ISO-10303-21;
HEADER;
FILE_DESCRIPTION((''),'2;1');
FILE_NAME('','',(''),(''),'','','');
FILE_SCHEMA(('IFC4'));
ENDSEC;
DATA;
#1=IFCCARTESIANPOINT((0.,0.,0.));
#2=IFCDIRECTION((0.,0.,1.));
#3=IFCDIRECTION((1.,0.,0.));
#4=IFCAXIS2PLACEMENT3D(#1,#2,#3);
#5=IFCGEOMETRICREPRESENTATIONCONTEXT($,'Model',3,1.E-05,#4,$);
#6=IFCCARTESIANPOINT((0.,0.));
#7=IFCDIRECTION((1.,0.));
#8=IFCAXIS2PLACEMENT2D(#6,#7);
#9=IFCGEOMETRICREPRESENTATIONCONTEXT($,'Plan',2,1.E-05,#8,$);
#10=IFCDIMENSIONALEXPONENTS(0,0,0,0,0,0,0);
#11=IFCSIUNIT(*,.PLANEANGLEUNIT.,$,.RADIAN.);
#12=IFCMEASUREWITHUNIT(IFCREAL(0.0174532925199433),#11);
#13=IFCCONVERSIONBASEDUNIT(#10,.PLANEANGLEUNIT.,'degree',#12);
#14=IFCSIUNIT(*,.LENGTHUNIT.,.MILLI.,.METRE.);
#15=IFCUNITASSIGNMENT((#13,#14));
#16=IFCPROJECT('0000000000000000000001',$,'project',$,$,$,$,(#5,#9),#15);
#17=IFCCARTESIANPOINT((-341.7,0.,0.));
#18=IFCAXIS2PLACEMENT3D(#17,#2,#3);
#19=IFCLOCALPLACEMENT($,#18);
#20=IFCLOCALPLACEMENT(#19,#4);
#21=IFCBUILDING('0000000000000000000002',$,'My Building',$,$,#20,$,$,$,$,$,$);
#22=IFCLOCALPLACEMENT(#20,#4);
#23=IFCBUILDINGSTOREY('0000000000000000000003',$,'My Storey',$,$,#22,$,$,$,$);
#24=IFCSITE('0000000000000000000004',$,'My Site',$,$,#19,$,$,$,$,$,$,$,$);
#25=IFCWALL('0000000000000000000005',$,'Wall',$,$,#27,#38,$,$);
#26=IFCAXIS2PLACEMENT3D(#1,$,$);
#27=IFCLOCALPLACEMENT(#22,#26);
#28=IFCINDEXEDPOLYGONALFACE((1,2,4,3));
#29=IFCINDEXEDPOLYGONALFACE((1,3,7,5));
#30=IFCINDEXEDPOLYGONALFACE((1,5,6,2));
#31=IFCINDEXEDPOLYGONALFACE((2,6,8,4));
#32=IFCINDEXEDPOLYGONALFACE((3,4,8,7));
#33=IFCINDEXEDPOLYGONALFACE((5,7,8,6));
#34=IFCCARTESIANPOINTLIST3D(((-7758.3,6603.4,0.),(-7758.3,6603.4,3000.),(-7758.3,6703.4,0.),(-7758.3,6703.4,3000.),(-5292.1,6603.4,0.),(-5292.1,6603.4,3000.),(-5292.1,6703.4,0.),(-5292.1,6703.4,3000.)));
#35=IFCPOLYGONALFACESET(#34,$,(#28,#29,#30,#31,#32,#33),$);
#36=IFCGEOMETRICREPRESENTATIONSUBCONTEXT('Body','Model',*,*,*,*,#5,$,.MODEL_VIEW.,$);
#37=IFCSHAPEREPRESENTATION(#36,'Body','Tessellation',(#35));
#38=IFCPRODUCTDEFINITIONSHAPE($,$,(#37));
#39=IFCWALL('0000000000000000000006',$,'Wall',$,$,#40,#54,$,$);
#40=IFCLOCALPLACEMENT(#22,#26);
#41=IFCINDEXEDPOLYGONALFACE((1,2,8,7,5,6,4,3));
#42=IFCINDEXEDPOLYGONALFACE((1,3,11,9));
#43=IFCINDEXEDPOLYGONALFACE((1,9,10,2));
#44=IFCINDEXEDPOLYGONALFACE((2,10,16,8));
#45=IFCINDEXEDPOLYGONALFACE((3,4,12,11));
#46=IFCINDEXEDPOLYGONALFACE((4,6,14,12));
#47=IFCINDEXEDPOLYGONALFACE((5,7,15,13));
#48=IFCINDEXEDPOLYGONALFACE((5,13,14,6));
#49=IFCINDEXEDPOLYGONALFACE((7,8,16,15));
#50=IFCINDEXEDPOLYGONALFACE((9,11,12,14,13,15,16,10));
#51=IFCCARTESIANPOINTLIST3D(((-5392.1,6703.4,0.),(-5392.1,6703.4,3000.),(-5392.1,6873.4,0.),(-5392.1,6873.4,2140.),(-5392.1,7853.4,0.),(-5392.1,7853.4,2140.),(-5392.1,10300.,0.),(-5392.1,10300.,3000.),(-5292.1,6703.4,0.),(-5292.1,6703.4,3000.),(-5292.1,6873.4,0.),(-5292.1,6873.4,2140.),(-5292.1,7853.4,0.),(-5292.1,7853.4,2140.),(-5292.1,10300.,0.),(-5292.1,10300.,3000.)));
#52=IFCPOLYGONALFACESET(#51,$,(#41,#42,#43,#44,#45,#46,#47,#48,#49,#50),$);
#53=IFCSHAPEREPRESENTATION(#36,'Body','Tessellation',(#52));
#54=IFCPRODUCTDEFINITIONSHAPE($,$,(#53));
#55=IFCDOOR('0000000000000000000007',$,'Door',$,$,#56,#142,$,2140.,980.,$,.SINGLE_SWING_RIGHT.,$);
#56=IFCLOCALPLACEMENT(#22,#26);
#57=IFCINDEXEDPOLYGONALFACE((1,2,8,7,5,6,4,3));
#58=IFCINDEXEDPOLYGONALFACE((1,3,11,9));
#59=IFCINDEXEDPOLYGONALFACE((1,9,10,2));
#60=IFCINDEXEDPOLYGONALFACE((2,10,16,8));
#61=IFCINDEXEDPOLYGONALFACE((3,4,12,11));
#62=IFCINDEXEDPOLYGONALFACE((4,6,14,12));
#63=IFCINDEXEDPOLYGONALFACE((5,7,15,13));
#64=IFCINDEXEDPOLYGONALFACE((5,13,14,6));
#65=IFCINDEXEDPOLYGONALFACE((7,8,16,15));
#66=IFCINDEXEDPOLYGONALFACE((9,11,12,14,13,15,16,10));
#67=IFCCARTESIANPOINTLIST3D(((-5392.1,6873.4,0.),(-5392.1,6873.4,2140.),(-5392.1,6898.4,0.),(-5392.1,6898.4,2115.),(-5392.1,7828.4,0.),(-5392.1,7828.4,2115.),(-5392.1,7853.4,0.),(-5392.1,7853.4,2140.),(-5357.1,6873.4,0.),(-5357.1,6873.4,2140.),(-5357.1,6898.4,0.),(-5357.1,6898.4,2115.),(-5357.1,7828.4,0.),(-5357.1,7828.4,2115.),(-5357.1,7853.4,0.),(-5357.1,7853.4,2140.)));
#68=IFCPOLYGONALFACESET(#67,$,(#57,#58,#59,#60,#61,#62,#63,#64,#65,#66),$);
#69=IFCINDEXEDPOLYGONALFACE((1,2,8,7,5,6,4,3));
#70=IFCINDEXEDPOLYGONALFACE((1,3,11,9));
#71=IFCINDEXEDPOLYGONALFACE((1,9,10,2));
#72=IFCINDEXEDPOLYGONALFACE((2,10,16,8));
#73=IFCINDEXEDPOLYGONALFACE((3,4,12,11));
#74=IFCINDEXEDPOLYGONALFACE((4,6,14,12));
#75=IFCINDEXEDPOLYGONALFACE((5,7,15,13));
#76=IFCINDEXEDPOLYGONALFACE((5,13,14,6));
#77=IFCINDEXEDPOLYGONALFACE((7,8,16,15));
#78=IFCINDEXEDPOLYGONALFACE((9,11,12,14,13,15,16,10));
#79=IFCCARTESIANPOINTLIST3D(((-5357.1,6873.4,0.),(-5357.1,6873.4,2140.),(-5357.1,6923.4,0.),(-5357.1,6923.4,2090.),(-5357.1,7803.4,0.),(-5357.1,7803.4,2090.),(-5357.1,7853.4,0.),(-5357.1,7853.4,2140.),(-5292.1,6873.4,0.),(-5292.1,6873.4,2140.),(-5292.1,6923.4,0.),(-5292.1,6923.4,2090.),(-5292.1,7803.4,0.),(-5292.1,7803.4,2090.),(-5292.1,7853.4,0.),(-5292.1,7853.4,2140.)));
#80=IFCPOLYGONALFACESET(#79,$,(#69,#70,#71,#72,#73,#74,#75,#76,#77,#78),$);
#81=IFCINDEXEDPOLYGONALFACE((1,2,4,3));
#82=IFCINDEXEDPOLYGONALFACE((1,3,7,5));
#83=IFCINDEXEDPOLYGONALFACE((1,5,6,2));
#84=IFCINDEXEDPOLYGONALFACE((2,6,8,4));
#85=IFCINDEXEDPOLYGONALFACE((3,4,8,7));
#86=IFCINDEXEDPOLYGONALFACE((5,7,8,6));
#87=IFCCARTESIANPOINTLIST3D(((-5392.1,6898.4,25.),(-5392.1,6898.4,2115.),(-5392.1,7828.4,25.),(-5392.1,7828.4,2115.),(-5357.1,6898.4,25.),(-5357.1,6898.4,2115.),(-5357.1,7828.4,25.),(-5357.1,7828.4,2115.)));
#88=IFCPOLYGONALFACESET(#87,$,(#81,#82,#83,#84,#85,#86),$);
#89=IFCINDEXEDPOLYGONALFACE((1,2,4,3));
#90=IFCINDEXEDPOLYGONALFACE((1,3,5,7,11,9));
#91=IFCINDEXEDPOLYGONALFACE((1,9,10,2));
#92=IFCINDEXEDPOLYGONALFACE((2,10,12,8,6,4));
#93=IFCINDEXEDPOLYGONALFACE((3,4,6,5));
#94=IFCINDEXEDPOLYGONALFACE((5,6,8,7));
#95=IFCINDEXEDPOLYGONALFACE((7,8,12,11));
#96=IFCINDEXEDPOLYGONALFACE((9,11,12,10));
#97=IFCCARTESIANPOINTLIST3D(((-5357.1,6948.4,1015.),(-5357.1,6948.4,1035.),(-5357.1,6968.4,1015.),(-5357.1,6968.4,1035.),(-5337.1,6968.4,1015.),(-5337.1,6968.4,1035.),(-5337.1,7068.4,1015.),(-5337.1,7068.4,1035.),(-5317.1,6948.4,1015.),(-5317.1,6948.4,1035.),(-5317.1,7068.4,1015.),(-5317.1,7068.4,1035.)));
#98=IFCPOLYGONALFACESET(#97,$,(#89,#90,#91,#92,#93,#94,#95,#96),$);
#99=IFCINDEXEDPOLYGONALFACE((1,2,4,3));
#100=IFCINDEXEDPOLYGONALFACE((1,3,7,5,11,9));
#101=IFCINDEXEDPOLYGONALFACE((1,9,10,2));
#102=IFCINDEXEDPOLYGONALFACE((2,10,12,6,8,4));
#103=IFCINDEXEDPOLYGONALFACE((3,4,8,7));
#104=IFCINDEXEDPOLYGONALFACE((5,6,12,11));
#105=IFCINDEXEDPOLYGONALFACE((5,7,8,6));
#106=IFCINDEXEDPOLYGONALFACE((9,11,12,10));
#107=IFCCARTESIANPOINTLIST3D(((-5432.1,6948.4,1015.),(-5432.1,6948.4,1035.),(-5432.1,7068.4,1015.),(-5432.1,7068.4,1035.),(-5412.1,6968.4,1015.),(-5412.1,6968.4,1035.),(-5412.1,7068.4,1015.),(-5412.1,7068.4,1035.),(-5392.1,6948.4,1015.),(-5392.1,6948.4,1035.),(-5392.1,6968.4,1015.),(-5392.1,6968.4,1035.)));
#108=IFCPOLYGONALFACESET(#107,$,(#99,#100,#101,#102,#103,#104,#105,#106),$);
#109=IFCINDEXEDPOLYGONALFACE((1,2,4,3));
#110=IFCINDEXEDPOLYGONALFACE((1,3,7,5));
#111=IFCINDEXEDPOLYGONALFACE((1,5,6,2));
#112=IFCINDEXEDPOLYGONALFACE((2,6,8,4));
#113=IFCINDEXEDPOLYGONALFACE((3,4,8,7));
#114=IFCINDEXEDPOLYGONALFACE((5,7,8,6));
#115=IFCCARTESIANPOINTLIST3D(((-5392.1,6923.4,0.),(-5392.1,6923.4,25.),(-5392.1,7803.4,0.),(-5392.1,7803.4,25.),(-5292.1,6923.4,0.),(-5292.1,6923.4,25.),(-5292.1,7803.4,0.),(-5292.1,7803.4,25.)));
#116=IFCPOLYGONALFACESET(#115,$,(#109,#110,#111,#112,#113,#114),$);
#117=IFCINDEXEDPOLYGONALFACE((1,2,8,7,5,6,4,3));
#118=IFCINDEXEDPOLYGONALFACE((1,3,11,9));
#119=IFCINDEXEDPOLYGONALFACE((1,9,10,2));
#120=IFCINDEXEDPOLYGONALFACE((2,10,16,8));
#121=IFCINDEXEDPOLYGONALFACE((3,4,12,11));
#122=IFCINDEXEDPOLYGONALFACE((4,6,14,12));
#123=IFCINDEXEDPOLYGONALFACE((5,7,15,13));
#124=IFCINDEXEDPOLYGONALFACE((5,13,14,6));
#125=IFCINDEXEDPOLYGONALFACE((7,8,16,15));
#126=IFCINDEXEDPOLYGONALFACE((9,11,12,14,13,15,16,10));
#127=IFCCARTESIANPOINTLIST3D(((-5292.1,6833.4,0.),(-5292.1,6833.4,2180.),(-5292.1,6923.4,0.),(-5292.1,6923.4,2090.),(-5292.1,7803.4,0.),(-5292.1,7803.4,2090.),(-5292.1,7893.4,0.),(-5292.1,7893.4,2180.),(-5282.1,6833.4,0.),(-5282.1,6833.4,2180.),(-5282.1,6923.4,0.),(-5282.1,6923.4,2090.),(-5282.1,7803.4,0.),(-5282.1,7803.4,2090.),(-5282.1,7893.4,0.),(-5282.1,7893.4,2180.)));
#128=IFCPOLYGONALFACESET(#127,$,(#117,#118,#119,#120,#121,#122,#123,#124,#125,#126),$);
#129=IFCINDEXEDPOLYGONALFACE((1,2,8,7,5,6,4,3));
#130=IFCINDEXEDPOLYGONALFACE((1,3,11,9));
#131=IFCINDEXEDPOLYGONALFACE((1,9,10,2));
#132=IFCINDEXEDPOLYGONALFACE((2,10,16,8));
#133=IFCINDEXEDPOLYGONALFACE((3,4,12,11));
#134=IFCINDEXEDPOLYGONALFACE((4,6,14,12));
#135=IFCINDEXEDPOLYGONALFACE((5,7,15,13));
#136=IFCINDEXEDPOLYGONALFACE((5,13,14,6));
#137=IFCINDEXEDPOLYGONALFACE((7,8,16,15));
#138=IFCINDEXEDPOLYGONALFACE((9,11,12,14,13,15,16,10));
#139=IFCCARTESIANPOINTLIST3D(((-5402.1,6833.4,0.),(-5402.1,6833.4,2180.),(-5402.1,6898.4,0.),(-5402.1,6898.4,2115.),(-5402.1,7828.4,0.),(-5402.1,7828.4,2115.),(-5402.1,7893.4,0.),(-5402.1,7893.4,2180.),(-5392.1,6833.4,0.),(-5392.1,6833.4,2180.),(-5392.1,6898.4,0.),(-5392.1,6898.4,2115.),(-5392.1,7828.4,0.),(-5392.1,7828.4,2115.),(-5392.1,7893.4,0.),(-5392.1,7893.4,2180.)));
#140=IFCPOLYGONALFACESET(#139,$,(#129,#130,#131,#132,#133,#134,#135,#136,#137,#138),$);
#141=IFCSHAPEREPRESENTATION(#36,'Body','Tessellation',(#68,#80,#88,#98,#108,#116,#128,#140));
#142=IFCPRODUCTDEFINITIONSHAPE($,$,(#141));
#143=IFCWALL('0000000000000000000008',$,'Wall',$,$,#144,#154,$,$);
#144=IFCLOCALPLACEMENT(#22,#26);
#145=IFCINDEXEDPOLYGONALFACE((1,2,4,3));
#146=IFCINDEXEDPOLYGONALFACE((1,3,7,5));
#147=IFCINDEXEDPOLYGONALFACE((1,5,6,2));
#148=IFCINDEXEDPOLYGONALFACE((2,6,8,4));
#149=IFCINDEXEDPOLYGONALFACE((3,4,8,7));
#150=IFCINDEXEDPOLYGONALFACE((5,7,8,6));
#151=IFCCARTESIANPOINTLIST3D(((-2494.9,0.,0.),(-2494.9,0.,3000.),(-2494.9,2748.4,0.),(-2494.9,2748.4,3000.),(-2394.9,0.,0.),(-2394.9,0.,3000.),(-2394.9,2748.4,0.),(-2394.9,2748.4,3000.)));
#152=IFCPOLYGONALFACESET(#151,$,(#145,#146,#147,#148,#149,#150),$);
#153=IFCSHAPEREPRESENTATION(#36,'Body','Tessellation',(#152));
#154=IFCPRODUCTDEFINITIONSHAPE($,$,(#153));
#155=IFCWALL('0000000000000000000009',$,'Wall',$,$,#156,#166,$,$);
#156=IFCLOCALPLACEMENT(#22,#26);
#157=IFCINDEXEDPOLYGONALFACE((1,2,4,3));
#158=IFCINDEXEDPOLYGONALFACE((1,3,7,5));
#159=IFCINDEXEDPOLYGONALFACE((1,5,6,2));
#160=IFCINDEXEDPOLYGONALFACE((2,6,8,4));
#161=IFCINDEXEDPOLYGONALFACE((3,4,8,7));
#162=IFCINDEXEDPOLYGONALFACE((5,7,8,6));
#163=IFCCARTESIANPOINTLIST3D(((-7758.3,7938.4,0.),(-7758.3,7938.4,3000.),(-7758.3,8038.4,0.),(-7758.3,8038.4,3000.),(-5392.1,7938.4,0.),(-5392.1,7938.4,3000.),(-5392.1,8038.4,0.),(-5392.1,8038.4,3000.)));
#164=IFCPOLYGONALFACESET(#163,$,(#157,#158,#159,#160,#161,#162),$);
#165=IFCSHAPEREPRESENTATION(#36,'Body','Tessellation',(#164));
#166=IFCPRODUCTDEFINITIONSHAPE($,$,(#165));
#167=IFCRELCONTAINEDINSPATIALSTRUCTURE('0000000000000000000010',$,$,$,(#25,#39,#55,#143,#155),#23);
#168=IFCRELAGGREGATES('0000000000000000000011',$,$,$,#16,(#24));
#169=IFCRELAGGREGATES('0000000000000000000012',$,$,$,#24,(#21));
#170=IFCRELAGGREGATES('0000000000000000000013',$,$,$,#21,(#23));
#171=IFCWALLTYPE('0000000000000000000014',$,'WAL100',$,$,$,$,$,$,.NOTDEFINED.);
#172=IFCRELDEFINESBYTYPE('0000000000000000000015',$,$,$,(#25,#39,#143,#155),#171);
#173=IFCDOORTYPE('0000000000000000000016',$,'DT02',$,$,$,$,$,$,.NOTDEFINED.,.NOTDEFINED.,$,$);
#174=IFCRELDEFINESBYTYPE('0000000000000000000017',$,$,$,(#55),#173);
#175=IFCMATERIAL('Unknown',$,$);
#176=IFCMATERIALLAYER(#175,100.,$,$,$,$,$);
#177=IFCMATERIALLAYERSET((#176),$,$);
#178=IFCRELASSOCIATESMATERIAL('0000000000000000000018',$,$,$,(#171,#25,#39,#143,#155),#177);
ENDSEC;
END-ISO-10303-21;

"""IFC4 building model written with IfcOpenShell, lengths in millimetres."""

from ifc_helpers import new_model, entity, si_unit, converted_unit, frame, origin_with_axes, origin_2d_with_axis, place, context, subcontext, project, spatial, line, indexed_curve, outline, extrude, shape, source, transform, mapped, material, layer, layer_set, layer_usage, type_object, type_shapes, element, fill, save


model = new_model("IFC4")

# Units and contexts
model_context = context("Model", 3, precision=1e-05, world=origin_with_axes())
plan_context = context("Plan", 2, precision=1e-05, world=origin_2d_with_axis())
body_context_1 = subcontext(model_context, "Body", "Model", "MODEL_VIEW")
body_context_2 = subcontext(plan_context, "Body", "Plan", "PLAN_VIEW")
ifc_project = project(units=[converted_unit("PLANEANGLEUNIT", "degree", entity("IfcReal", 0.0174532925199433), si_unit("PLANEANGLEUNIT", "RADIAN"), dimensions=[0, 0, 0, 0, 0, 0, 0]), si_unit("LENGTHUNIT", "METRE", prefix="MILLI")], contexts=[model_context, plan_context])

# Site, building, storey
site_placement = place(None, frame((-341.7, 0.0, 0.0), z_axis=(0.0, 0.0, 1.0), x_axis=(1.0, 0.0, 0.0)))
site = spatial("IfcSite", under=ifc_project, at=site_placement, Name="My Site")
building_placement = place(site_placement, origin_with_axes())
building = spatial("IfcBuilding", under=site, at=building_placement, Name="My Building")
storey_placement = place(building_placement, origin_with_axes())
storey = spatial("IfcBuildingStorey", under=building, at=storey_placement, Name="My Storey")

# Wall
ifc_material = material(Name="Unknown")
ifc_layer_1 = layer(ifc_material, 100.0)
ifc_layer_set_1 = layer_set([ifc_layer_1])
ifc_layer_usage_1 = layer_usage(ifc_layer_set_1, "AXIS2", "POSITIVE", 0.0)
wall_type_1 = type_object("IfcWallType", Name="WAL100", PredefinedType="NOTDEFINED", material=ifc_layer_set_1)
wall_1_placement = place(storey_placement, frame((-7758.3, 6603.4, 0.0), z_axis=(0.0, 0.0, 1.0), x_axis=(1.0, 0.0, 0.0)))
element("IfcWall", 1, at=wall_1_placement, inside=storey, type_object=wall_type_1, material=ifc_layer_usage_1, Name="Wall", context=body_context_1, shape_type="SweptSolid", body=[
    extrude(outline(indexed_curve([(0.0, 0.0), (0.0, 100.0), (2466.2, 100.0), (2466.2, 0.0), (0.0, 0.0)], self_intersect=False)), origin_with_axes(), (0.0, 0.0, 1.0), 3000.0),
])

# Wall, opening, door
ifc_layer_usage_2 = layer_usage(ifc_layer_set_1, "AXIS2", "POSITIVE", 0.0)
wall_2_placement = place(storey_placement, frame((-5292.1, 6703.4, 0.0), z_axis=(0.0, 0.0, 1.0), x_axis=(0.0, 1.0, 0.0)))
wall_2 = element("IfcWall", 2, at=wall_2_placement, inside=storey, type_object=wall_type_1, material=ifc_layer_usage_2, Name="Wall", context=body_context_1, shape_type="SweptSolid", body=[
    extrude(outline(indexed_curve([(0.0, 0.0), (0.0, 100.0), (3596.6, 100.0), (3596.6, 0.0), (0.0, 0.0)], self_intersect=False)), origin_with_axes(), (0.0, 0.0, 1.0), 3000.0),
])
shared_shape_1 = source(origin_with_axes(), body_context_1, "Body", "SweptSolid", [
    extrude(outline(indexed_curve([(0.0, 0.0), (980.0, 0.0), (980.0, 2140.0), (0.0, 2140.0)], segments=[line(1, 2, 3, 4, 1)])), frame((0.0, -100.0, 0.0), z_axis=(0.0, -1.0, 0.0), x_axis=(1.0, 0.0, 0.0)), (0.0, 0.0, -1.0), 300.0),
])
opening_1_placement = place(wall_2_placement, frame((170.0, 0.0, 0.0), z_axis=(0.0, 0.0, 1.0), x_axis=(1.0, 0.0, 0.0)))
opening_1 = element("IfcOpeningElement", 3, at=opening_1_placement, cuts=wall_2, PredefinedType="OPENING", context=body_context_1, shape_type="MappedRepresentation", body=[
    mapped(shared_shape_1, transform((0.0, 0.0, 0.0), x_axis=(1.0, 0.0, 0.0), y_axis=(0.0, 1.0, 0.0), z_axis=(0.0, 0.0, 1.0), scale=1.0)),
])
door_type_1 = type_object("IfcDoorType", Name="DT02", OperationType="NOTDEFINED", PredefinedType="NOTDEFINED")
shared_shape_2 = source(origin_with_axes(), body_context_1, "Body", "SweptSolid", [
    extrude(outline(indexed_curve([(0.0, 0.0), (0.0, 2140.0), (980.0, 2140.0), (980.0, 0.0), (955.0, 0.0), (955.0, 2115.0), (25.0, 2115.0), (25.0, 0.0)], segments=[line(1, 2, 3, 4, 5, 6, 7, 8, 1)])), frame((0.0, 65.0, 0.0), z_axis=(0.0, -1.0, 0.0), x_axis=(1.0, 0.0, 0.0)), (0.0, 0.0, -1.0), 35.0),
    extrude(outline(indexed_curve([(0.0, 0.0), (0.0, 2140.0), (980.0, 2140.0), (980.0, 0.0), (930.0, 0.0), (930.0, 2090.0), (50.0, 2090.0), (50.0, 0.0)], segments=[line(1, 2, 3, 4, 5, 6, 7, 8, 1)])), frame((0.0, 0.0, 0.0), z_axis=(0.0, -1.0, 0.0), x_axis=(1.0, 0.0, 0.0)), (0.0, 0.0, -1.0), 65.0),
    extrude(outline(indexed_curve([(0.0, 0.0), (930.0, 0.0), (930.0, 35.0), (0.0, 35.0)], segments=[line(1, 2, 3, 4, 1)])), frame((25.0, 65.0, 25.0), z_axis=(0.0, 0.0, 1.0), x_axis=(1.0, 0.0, 0.0)), (0.0, 0.0, 1.0), 2090.0),
    extrude(outline(indexed_curve([(0.0, 0.0), (0.0, -40.0), (120.0, -40.0), (120.0, -20.0), (20.0, -20.0), (20.0, 0.0)], segments=[line(1, 2, 3, 4, 5, 6, 1)])), frame((75.0, 65.0, 1015.0), z_axis=(0.0, 0.0, 1.0), x_axis=(1.0, 0.0, 0.0)), (0.0, 0.0, 1.0), 20.0),
    extrude(outline(indexed_curve([(0.0, 0.0), (0.0, 40.0), (120.0, 40.0), (120.0, 20.0), (20.0, 20.0), (20.0, 0.0)], segments=[line(1, 2, 3, 4, 5, 6, 1)])), frame((75.0, 100.0, 1015.0), z_axis=(0.0, 0.0, 1.0), x_axis=(1.0, 0.0, 0.0)), (0.0, 0.0, 1.0), 20.0),
    extrude(outline(indexed_curve([(0.0, 0.0), (880.0, 0.0), (880.0, 100.0), (0.0, 100.0)], segments=[line(1, 2, 3, 4, 1)])), frame((50.0, 0.0, 0.0), z_axis=(0.0, 0.0, 1.0), x_axis=(1.0, 0.0, 0.0)), (0.0, 0.0, 1.0), 25.0),
    extrude(outline(indexed_curve([(0.0, 0.0), (0.0, 2180.0), (1060.0, 2180.0), (1060.0, 0.0), (970.0, 0.0), (970.0, 2090.0), (90.0, 2090.0), (90.0, 0.0)], segments=[line(1, 2, 3, 4, 5, 6, 7, 8, 1)])), frame((-40.0, -10.0, 0.0), z_axis=(0.0, -1.0, 0.0), x_axis=(1.0, 0.0, 0.0)), (0.0, 0.0, -1.0), 10.0),
    extrude(outline(indexed_curve([(0.0, 0.0), (0.0, 2180.0), (1060.0, 2180.0), (1060.0, 0.0), (995.0, 0.0), (995.0, 2115.0), (65.0, 2115.0), (65.0, 0.0)], segments=[line(1, 2, 3, 4, 5, 6, 7, 8, 1)])), frame((-40.0, 100.0, 0.0), z_axis=(0.0, -1.0, 0.0), x_axis=(1.0, 0.0, 0.0)), (0.0, 0.0, -1.0), 10.0),
])
shared_shape_3 = source(origin_with_axes(), body_context_2, "Body", "Curve2D", [
    entity("IfcIndexedPolyCurve", entity("IfcCartesianPointList2D", [[0.0, 0.0], [0.0, 100.0], [25.0, 100.0], [25.0, 65.0], [50.0, 65.0], [50.0, 0.0]]), [entity("IfcLineIndex", [1, 2, 3, 4, 5, 6, 1])]),
    entity("IfcIndexedPolyCurve", entity("IfcCartesianPointList2D", [[980.0, 0.0], [980.0, 100.0], [955.0, 100.0], [955.0, 65.0], [930.0, 65.0], [930.0, 0.0]]), [entity("IfcLineIndex", [1, 2, 3, 4, 5, 6, 1])]),
    entity("IfcTrimmedCurve", entity("IfcEllipse", entity("IfcAxis2Placement2D", entity("IfcCartesianPoint", [920.0, 100.0]), entity("IfcDirection", [1.0, 0.0])), 895.0, 930.0), [entity("IfcCartesianPoint", [920.0, 1030.0])], [entity("IfcCartesianPoint", [25.0, 100.0])], True, "CARTESIAN"),
    entity("IfcIndexedPolyCurve", entity("IfcCartesianPointList2D", [[955.0, 100.0], [920.0, 100.0], [920.0, 1030.0], [955.0, 1030.0]]), [entity("IfcLineIndex", [1, 2, 3, 4, 1])]),
])
type_shapes(door_type_1, [shared_shape_2, shared_shape_3])
door_1_placement = place(opening_1_placement, frame((0.0, 0.0, 0.0), z_axis=(0.0, 0.0, 1.0), x_axis=(1.0, 0.0, 0.0)))
door_1 = element("IfcDoor", 4, at=door_1_placement, inside=storey, type_object=door_type_1, Name="Door", OperationType="SINGLE_SWING_RIGHT", OverallHeight=2140.0, OverallWidth=980.0, shapes=[
    shape(body_context_1, "Body", "MappedRepresentation", [mapped(shared_shape_2, transform((0.0, 0.0, 0.0), x_axis=(1.0, 0.0, 0.0), y_axis=(0.0, 1.0, 0.0), z_axis=(0.0, 0.0, 1.0), scale=1.0))]),
    shape(body_context_2, "Body", "MappedRepresentation", [mapped(shared_shape_3, transform((0.0, 0.0, 0.0), x_axis=(1.0, 0.0, 0.0), y_axis=(0.0, 1.0, 0.0), z_axis=(0.0, 0.0, 1.0), scale=1.0))]),
])
fill(opening_1, door_1)

# Walls
ifc_layer_usage_3 = layer_usage(ifc_layer_set_1, "AXIS2", "POSITIVE", 0.0)
wall_3_placement = place(storey_placement, frame((-2494.9, 2748.4, 0.0), z_axis=(0.0, 0.0, 1.0), x_axis=(0.0, -1.0, 0.0)))
element("IfcWall", 5, at=wall_3_placement, inside=storey, type_object=wall_type_1, material=ifc_layer_usage_3, Name="Wall", context=body_context_1, shape_type="SweptSolid", body=[
    extrude(outline(indexed_curve([(0.0, 0.0), (0.0, 100.0), (2748.4, 100.0), (2748.4, 0.0), (0.0, 0.0)], self_intersect=False)), origin_with_axes(), (0.0, 0.0, 1.0), 3000.0),
])
ifc_layer_usage_4 = layer_usage(ifc_layer_set_1, "AXIS2", "POSITIVE", 0.0)
wall_4_placement = place(storey_placement, frame((-7758.3, 7938.4, 0.0), z_axis=(0.0, 0.0, 1.0), x_axis=(1.0, 0.0, 0.0)))
element("IfcWall", 6, at=wall_4_placement, inside=storey, type_object=wall_type_1, material=ifc_layer_usage_4, Name="Wall", context=body_context_1, shape_type="SweptSolid", body=[
    extrude(outline(indexed_curve([(0.0, 0.0), (0.0, 100.0), (2366.2, 100.0), (2366.2, 0.0), (0.0, 0.0)], self_intersect=False)), origin_with_axes(), (0.0, 0.0, 1.0), 3000.0),
])

save(model, "model.ifc")
